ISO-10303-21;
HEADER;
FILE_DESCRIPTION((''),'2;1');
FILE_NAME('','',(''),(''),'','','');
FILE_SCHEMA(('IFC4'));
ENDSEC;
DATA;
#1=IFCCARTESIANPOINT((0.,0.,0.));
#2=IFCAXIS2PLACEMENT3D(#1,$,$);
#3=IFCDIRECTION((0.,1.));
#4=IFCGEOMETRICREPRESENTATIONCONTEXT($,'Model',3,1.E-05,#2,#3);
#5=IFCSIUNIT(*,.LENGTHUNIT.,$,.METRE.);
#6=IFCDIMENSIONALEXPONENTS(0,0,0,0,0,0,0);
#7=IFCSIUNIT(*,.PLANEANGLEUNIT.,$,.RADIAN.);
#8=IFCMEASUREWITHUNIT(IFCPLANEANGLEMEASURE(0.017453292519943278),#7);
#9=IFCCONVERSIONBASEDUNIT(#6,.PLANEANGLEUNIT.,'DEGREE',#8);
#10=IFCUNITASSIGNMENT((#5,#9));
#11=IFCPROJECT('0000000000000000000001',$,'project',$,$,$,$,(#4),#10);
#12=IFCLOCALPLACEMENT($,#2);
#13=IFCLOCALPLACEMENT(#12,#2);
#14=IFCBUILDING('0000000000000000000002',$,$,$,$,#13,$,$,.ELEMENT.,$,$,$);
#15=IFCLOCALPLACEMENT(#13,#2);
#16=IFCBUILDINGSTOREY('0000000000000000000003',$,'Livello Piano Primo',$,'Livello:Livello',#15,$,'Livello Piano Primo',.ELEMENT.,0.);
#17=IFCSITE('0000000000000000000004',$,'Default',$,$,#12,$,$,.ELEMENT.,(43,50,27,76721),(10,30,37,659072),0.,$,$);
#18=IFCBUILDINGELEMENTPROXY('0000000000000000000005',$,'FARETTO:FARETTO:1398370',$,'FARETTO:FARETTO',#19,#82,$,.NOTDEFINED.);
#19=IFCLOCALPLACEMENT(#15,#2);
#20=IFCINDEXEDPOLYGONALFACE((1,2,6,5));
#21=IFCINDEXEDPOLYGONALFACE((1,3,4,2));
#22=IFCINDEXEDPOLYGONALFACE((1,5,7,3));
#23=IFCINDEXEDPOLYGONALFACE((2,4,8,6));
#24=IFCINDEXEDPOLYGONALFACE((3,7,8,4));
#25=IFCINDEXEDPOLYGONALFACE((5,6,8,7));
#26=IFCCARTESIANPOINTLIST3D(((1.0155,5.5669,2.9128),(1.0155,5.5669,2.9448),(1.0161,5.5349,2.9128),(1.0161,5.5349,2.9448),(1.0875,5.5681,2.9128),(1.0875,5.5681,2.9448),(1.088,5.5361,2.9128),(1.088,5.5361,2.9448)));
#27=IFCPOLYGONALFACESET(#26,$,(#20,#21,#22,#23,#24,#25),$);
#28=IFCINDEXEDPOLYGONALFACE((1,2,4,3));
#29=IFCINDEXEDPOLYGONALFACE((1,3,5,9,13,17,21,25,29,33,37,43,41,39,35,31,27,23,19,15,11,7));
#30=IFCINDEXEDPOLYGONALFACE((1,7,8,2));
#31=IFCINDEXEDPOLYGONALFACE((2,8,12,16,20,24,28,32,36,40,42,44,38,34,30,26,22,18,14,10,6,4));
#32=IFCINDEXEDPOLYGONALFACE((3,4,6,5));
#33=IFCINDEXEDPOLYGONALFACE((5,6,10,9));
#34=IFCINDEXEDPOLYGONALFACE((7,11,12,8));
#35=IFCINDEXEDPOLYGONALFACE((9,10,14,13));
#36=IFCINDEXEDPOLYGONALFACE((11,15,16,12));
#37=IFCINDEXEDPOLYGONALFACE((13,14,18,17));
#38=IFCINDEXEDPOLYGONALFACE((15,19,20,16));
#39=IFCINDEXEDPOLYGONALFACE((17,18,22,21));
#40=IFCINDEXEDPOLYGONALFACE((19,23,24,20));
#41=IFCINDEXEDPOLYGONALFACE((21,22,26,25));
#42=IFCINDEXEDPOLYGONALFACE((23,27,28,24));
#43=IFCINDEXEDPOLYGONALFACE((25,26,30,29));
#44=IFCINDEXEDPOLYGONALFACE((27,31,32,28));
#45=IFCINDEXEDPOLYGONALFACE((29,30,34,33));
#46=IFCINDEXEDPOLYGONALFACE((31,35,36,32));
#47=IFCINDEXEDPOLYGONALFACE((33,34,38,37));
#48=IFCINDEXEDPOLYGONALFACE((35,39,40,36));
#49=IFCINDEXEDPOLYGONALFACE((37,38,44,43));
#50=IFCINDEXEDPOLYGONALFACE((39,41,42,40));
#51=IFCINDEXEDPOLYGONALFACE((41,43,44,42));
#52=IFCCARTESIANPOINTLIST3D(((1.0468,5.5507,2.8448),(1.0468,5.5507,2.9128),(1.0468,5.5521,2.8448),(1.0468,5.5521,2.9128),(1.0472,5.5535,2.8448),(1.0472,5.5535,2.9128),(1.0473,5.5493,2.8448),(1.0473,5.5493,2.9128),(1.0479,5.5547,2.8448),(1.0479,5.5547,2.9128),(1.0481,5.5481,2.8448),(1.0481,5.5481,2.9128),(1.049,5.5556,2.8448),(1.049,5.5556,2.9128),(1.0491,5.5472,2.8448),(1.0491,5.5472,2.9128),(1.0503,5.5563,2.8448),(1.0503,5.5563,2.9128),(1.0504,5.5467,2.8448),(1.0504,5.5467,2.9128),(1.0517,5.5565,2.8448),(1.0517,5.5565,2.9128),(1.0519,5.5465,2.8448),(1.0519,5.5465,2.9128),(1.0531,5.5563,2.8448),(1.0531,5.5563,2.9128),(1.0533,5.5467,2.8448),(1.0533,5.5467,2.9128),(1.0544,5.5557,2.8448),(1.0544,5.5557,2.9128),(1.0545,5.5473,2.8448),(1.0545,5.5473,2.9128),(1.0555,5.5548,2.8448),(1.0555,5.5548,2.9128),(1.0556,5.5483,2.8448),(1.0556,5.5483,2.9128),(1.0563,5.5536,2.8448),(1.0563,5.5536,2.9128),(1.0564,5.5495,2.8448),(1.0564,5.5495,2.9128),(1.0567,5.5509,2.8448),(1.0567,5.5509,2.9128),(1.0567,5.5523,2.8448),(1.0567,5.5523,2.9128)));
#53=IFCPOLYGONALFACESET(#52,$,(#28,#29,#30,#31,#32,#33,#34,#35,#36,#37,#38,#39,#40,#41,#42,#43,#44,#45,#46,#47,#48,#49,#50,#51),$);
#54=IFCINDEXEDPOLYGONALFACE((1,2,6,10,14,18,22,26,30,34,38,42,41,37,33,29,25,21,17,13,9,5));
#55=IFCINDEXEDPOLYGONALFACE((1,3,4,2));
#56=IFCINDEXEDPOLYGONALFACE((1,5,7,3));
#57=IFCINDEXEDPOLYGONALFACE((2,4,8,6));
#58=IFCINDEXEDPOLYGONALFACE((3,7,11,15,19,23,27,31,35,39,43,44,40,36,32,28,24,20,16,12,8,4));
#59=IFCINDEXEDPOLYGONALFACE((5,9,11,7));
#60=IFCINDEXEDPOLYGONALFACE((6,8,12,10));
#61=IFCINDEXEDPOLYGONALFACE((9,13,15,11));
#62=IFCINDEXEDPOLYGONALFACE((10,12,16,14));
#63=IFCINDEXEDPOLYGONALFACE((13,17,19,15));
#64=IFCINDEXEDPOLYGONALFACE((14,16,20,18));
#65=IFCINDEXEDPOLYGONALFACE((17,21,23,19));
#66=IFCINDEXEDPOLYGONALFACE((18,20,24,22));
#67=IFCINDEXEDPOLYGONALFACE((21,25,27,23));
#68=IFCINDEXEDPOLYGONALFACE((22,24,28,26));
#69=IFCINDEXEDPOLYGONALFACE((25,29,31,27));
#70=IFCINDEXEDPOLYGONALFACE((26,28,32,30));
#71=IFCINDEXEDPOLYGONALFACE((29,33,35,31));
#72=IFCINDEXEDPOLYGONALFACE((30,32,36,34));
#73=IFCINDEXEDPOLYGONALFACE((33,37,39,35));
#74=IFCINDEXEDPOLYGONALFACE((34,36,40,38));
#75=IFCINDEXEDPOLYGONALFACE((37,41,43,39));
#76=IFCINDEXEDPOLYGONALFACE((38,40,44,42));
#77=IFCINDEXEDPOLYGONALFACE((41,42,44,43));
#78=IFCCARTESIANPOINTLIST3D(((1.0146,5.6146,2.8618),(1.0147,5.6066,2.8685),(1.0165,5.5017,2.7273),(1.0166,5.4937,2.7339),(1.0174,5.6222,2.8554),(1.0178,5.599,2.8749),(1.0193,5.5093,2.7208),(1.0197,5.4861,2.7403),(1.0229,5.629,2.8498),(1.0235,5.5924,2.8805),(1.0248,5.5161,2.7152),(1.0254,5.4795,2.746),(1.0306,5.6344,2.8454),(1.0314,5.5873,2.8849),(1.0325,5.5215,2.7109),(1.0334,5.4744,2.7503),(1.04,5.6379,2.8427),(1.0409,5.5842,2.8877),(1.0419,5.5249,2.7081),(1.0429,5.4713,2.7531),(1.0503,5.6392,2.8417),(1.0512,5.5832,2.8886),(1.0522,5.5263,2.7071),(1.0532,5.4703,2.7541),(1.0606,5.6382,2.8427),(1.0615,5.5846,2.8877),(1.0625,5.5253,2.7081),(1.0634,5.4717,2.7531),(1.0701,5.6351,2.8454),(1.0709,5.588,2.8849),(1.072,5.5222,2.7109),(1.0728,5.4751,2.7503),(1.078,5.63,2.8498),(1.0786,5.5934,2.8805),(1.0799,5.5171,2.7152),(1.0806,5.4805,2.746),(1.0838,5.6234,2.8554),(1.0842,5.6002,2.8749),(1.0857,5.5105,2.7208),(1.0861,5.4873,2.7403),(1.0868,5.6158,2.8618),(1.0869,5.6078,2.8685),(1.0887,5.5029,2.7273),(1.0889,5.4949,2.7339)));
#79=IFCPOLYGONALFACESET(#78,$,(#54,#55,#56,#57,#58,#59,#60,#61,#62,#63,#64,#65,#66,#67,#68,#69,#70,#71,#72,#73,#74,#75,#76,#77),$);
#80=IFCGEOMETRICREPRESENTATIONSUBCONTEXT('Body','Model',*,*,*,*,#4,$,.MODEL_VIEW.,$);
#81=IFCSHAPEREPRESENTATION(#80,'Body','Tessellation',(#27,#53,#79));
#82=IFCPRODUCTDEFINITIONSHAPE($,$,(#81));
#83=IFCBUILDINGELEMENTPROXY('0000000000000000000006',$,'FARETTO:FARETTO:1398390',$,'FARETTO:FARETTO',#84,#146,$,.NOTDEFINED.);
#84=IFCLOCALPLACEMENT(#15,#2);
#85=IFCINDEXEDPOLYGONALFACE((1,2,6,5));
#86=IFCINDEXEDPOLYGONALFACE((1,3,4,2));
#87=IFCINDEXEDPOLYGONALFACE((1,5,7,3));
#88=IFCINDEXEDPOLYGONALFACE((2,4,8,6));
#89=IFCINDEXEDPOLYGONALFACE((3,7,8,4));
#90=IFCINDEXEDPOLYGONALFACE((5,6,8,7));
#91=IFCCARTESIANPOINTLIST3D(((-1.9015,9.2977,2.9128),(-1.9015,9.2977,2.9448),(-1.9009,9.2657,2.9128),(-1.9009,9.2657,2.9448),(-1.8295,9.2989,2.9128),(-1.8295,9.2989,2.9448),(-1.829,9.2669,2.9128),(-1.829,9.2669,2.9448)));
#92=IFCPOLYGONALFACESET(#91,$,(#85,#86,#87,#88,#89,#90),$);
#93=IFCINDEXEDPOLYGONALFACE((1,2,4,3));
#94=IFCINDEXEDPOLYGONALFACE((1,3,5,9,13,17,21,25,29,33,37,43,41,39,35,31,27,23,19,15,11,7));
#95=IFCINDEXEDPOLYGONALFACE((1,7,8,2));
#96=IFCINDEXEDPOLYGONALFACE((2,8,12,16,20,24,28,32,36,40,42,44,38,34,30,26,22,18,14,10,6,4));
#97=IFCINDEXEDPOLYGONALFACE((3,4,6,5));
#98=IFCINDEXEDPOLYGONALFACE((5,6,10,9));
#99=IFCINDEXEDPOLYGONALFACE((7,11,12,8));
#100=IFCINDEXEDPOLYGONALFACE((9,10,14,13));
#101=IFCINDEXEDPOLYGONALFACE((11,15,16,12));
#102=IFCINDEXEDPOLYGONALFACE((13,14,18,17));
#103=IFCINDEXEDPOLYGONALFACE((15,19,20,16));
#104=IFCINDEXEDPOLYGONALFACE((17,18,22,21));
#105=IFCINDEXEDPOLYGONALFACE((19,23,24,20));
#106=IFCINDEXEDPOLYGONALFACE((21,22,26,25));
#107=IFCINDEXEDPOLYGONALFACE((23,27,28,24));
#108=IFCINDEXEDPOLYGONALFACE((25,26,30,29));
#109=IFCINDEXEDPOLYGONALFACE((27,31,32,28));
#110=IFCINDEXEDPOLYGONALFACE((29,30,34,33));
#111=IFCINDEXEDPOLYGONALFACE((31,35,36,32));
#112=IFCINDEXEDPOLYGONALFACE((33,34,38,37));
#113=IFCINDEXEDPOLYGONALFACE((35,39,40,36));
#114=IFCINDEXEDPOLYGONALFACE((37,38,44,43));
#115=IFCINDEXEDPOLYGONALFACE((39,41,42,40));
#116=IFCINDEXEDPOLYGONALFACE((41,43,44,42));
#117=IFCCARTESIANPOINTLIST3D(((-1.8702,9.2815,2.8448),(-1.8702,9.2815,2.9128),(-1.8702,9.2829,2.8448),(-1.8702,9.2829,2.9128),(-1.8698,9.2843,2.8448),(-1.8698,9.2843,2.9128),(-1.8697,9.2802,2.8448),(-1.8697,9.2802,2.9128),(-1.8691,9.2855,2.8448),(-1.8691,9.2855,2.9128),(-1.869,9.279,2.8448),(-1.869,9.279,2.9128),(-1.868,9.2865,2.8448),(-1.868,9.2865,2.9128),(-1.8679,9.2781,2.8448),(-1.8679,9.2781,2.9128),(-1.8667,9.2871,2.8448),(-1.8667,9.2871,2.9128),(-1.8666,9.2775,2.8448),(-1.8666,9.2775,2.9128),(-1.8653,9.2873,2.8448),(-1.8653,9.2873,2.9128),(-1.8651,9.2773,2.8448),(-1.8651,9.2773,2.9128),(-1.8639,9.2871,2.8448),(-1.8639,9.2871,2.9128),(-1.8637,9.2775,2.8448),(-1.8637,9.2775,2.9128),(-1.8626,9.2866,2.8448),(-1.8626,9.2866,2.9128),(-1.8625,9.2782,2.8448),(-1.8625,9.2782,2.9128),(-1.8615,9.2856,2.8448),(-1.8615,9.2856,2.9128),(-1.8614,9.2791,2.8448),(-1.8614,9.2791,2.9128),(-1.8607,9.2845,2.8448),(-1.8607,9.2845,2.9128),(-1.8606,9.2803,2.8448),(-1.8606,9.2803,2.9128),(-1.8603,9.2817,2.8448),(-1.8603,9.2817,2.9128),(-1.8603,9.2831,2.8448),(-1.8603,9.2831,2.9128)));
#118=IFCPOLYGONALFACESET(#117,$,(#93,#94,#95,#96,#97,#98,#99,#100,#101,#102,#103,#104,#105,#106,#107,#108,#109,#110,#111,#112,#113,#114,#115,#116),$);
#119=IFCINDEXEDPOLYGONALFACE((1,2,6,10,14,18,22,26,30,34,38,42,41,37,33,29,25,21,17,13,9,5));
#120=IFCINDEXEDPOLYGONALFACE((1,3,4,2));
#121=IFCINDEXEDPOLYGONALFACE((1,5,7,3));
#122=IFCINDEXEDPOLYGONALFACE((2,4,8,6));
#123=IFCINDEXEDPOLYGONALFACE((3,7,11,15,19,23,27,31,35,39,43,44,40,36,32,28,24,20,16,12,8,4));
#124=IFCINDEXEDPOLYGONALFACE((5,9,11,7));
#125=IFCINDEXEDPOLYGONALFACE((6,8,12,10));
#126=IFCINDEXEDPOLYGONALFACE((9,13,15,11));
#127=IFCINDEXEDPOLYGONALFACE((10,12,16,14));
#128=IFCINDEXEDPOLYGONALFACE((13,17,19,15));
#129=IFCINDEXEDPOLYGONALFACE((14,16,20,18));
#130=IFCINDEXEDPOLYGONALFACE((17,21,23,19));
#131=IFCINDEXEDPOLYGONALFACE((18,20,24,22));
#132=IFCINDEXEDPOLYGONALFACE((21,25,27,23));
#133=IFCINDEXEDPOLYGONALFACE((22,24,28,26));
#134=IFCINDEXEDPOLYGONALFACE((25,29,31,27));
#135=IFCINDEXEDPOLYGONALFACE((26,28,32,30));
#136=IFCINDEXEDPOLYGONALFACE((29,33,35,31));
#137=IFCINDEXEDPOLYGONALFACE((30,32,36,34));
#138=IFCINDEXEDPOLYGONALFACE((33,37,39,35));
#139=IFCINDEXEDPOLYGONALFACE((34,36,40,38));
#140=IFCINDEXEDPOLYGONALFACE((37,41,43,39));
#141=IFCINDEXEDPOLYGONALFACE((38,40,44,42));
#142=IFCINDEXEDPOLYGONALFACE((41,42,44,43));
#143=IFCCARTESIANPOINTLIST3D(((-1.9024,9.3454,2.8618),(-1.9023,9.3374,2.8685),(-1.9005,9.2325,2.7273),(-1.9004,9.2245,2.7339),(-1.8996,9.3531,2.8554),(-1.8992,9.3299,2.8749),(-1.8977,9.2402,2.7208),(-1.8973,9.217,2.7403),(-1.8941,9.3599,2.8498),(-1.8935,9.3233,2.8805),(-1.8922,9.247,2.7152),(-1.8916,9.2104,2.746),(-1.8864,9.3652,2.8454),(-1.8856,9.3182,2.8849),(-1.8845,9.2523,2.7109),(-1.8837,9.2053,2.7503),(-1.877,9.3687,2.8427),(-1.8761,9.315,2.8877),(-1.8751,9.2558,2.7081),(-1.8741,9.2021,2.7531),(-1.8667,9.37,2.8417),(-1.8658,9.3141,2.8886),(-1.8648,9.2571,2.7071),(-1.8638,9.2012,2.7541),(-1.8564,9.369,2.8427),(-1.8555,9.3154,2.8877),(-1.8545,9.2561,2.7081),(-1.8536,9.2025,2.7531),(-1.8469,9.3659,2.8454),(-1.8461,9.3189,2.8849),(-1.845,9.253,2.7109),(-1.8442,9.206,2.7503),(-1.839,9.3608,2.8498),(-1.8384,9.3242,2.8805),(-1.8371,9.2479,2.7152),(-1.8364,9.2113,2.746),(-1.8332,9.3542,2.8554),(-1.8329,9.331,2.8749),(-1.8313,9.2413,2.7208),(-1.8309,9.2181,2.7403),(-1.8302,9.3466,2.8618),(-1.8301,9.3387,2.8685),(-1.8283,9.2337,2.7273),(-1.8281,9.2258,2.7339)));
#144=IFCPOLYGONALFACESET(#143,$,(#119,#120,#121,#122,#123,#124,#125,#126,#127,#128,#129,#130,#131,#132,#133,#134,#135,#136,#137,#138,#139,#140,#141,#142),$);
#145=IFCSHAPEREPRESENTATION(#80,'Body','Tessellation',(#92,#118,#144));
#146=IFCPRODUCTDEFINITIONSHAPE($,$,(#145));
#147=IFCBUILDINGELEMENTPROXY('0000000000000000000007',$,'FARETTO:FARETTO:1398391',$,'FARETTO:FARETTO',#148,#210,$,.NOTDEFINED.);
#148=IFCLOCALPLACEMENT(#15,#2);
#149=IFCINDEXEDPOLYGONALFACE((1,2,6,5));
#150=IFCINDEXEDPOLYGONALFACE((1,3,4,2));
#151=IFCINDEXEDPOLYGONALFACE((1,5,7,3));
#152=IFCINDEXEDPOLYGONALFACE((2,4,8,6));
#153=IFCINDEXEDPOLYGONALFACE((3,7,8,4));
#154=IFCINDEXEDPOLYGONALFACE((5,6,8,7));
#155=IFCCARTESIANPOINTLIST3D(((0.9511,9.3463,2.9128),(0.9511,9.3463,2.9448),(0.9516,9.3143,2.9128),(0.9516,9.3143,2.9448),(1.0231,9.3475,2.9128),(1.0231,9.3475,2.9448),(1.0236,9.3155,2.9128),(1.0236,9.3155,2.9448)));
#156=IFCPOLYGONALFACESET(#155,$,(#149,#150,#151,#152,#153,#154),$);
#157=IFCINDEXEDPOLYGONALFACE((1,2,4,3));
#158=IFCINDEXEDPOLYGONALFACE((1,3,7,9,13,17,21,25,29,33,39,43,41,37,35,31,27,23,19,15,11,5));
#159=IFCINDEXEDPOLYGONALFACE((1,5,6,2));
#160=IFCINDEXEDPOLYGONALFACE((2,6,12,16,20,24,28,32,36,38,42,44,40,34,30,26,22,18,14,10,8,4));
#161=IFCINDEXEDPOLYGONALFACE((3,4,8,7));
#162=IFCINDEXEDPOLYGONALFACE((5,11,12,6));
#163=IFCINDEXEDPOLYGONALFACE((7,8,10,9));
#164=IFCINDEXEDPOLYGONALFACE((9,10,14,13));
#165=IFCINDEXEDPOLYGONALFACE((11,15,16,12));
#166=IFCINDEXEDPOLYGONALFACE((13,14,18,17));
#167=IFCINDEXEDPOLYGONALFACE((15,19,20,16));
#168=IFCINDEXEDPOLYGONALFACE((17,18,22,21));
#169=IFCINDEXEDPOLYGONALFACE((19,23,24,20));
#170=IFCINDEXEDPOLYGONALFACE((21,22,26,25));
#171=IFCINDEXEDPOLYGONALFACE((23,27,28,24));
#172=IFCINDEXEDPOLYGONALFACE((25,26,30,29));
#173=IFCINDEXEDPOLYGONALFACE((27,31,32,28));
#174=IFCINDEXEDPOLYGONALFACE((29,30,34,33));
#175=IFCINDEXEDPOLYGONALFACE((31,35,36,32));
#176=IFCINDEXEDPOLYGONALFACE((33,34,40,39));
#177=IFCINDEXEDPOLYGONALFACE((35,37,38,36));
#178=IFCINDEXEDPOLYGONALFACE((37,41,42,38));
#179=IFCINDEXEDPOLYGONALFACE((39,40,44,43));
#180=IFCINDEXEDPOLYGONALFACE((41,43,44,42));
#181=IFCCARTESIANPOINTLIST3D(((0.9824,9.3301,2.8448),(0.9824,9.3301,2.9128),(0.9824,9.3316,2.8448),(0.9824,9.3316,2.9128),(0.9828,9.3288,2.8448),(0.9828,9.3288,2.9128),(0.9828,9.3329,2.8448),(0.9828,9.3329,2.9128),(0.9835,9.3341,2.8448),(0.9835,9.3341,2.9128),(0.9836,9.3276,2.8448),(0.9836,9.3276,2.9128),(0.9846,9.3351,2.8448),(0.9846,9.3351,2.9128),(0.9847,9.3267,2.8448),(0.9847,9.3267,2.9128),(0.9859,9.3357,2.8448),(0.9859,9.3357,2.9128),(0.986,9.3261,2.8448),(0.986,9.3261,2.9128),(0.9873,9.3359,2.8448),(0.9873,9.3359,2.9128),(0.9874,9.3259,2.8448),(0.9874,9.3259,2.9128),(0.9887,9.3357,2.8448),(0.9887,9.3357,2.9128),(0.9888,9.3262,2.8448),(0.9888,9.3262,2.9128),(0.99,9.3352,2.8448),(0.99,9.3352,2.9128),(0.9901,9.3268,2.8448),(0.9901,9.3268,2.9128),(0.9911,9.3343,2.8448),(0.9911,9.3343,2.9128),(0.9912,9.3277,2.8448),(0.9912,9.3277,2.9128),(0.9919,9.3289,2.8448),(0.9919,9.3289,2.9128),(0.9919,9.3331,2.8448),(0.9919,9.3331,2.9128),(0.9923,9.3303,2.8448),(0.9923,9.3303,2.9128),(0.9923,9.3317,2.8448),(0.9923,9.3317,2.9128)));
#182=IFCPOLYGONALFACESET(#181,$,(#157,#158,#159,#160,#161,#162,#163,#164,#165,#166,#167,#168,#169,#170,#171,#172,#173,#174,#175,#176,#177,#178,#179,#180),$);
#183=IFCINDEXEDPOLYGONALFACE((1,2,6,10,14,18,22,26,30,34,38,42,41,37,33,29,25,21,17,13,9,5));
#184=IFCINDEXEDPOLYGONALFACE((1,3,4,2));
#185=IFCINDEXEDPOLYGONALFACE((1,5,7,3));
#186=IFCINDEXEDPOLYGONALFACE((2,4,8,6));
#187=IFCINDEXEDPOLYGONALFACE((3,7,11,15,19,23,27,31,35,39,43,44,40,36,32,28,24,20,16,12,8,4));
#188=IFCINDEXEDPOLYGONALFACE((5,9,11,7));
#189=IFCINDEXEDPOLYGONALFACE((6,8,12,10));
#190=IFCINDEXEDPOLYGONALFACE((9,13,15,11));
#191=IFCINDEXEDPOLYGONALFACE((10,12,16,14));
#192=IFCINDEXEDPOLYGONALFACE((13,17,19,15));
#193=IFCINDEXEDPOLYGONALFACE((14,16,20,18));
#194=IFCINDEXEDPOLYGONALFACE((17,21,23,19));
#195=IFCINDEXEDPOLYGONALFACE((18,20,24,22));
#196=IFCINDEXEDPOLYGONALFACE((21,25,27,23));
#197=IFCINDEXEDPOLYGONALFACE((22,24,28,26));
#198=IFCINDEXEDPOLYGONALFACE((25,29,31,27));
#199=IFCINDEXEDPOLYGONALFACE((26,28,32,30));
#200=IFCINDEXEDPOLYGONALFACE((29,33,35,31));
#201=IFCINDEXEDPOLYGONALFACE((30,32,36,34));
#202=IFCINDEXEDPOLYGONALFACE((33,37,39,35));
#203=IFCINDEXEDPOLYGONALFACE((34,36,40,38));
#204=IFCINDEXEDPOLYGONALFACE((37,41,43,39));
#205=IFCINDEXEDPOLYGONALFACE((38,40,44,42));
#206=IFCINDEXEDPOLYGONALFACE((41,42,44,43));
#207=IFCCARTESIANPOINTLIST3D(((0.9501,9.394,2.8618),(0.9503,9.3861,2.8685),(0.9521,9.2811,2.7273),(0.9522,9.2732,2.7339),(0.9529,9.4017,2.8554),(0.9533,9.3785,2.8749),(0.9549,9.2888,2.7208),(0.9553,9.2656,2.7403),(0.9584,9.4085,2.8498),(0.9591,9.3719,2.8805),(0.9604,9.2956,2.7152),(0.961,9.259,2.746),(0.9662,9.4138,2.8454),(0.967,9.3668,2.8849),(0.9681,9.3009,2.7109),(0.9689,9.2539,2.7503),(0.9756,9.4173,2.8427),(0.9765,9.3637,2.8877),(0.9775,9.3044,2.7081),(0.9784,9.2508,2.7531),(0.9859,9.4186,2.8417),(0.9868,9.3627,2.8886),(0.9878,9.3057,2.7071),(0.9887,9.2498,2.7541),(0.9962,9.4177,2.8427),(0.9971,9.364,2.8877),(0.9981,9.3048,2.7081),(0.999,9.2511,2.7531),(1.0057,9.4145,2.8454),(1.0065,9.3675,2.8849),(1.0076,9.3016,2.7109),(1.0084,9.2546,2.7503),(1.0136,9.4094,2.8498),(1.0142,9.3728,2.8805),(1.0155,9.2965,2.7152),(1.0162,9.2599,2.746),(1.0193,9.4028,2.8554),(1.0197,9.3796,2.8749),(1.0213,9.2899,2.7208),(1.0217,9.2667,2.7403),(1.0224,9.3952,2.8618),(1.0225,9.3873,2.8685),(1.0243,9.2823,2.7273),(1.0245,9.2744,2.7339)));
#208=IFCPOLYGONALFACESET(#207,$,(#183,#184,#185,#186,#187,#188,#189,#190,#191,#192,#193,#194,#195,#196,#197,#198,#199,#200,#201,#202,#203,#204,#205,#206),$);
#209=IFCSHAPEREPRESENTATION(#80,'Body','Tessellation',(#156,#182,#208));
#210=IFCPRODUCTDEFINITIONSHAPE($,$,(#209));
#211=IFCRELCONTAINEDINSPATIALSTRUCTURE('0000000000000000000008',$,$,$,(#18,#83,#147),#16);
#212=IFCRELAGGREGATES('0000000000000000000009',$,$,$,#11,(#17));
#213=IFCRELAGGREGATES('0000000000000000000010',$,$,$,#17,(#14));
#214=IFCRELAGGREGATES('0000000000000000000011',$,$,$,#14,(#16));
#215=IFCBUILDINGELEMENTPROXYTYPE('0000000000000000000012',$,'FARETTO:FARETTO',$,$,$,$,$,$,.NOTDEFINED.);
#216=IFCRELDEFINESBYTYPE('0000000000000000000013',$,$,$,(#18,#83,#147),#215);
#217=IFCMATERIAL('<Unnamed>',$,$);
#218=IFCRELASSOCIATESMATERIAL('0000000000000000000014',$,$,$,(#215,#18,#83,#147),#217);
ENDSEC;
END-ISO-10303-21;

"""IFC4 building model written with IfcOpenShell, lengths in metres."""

from ifc_helpers import new_model, entity, si_unit, converted_unit, direction, frame, origin, place, context, subcontext, project, spatial, arc, indexed_curve, outline, extrude, source, transform, mapped, material, type_object, type_shapes, element, save


model = new_model("IFC4")

# Units and contexts
model_context = context("Model", 3, precision=1e-05, world=origin(), true_north=direction((0.0, 1.0)))
body_context = subcontext(model_context, "Body", "Model", "MODEL_VIEW")
ifc_project = project(units=[si_unit("LENGTHUNIT", "METRE"), converted_unit("PLANEANGLEUNIT", "DEGREE", entity("IfcPlaneAngleMeasure", 0.017453292519943278), si_unit("PLANEANGLEUNIT", "RADIAN"), dimensions=[0, 0, 0, 0, 0, 0, 0])], contexts=[model_context])

# Site, building, storey
site_placement = place(None, origin())
site = spatial("IfcSite", under=ifc_project, at=site_placement, Name="Default", CompositionType="ELEMENT", RefLatitude=(43, 50, 27, 76721), RefLongitude=(10, 30, 37, 659072), RefElevation=0.0)
building_placement = place(site_placement, origin())
building = spatial("IfcBuilding", under=site, at=building_placement, CompositionType="ELEMENT")
storey_placement = place(building_placement, origin())
storey = spatial("IfcBuildingStorey", under=building, at=storey_placement, Name="Livello Piano Primo", ObjectType="Livello:Livello", LongName="Livello Piano Primo", CompositionType="ELEMENT", Elevation=0.0)

# Building element proxies
ifc_material_1 = material(Name="<Unnamed>")
building_element_proxy_type_1 = type_object("IfcBuildingElementProxyType", Name="FARETTO:FARETTO", PredefinedType="NOTDEFINED", material=ifc_material_1)
shared_shape_1 = source(origin(), body_context, "Body", "SweptSolid", [
    extrude(outline(indexed_curve([(-0.036, -0.016), (0.036, -0.016), (0.036, 0.016), (-0.036, 0.016), (-0.036, -0.016)], self_intersect=False)), frame((0.032, 0.0, 0.0), z_axis=(0.0, 0.0, 1.0), x_axis=(0.0, 1.0, 0.0)), (0.0, 0.0, 1.0), 0.032),
    extrude(outline(indexed_curve([(-0.005, 0.0), (0.0, -0.005), (0.005, 0.0), (0.0, 0.005)], segments=[arc(1, 2, 3), arc(3, 4, 1)], self_intersect=False)), frame((0.032, 0.0, 0.032)), (0.0, 0.0, 1.0), 0.068),
    extrude(outline(indexed_curve([(-0.0365, 0.0), (0.0, -0.0365), (0.0365, 0.0), (0.0, 0.0365)], segments=[arc(1, 2, 3), arc(3, 4, 1)], self_intersect=False)), frame((-0.0277, 0.0, 0.0796), z_axis=(0.642788, 0.0, 0.766044), x_axis=(0.766044, 0.0, -0.642788)), (0.0, 0.0, 1.0), 0.1757),
])
type_shapes(building_element_proxy_type_1, [shared_shape_1])
for number, where, z_axis, x_axis, name in (
    (1, (1.0512, 5.5835, 2.9448), (0.0, 0.0, -1.0), (0.017041, -0.999855, 0.0), "FARETTO:FARETTO:1398370"),
    (2, (-1.8658, 9.3143, 2.9448), (0.0, 0.0, -1.0), (0.017041, -0.999855, 0.0), "FARETTO:FARETTO:1398390"),
    (3, (0.9868, 9.3629, 2.9448), (0.0, 0.0, -1.0), (0.017041, -0.999855, 0.0), "FARETTO:FARETTO:1398391"),
):
    element("IfcBuildingElementProxy", number, at=place(storey_placement, frame(where, z_axis=z_axis, x_axis=x_axis)), inside=storey, type_object=building_element_proxy_type_1, material=ifc_material_1, Name=name, ObjectType="FARETTO:FARETTO", PredefinedType="NOTDEFINED", context=body_context, shape_type="MappedRepresentation", body=[
        mapped(shared_shape_1, transform((0.0, 0.0, 0.0), scale=1.0)),
    ])

save(model, "model.ifc")
